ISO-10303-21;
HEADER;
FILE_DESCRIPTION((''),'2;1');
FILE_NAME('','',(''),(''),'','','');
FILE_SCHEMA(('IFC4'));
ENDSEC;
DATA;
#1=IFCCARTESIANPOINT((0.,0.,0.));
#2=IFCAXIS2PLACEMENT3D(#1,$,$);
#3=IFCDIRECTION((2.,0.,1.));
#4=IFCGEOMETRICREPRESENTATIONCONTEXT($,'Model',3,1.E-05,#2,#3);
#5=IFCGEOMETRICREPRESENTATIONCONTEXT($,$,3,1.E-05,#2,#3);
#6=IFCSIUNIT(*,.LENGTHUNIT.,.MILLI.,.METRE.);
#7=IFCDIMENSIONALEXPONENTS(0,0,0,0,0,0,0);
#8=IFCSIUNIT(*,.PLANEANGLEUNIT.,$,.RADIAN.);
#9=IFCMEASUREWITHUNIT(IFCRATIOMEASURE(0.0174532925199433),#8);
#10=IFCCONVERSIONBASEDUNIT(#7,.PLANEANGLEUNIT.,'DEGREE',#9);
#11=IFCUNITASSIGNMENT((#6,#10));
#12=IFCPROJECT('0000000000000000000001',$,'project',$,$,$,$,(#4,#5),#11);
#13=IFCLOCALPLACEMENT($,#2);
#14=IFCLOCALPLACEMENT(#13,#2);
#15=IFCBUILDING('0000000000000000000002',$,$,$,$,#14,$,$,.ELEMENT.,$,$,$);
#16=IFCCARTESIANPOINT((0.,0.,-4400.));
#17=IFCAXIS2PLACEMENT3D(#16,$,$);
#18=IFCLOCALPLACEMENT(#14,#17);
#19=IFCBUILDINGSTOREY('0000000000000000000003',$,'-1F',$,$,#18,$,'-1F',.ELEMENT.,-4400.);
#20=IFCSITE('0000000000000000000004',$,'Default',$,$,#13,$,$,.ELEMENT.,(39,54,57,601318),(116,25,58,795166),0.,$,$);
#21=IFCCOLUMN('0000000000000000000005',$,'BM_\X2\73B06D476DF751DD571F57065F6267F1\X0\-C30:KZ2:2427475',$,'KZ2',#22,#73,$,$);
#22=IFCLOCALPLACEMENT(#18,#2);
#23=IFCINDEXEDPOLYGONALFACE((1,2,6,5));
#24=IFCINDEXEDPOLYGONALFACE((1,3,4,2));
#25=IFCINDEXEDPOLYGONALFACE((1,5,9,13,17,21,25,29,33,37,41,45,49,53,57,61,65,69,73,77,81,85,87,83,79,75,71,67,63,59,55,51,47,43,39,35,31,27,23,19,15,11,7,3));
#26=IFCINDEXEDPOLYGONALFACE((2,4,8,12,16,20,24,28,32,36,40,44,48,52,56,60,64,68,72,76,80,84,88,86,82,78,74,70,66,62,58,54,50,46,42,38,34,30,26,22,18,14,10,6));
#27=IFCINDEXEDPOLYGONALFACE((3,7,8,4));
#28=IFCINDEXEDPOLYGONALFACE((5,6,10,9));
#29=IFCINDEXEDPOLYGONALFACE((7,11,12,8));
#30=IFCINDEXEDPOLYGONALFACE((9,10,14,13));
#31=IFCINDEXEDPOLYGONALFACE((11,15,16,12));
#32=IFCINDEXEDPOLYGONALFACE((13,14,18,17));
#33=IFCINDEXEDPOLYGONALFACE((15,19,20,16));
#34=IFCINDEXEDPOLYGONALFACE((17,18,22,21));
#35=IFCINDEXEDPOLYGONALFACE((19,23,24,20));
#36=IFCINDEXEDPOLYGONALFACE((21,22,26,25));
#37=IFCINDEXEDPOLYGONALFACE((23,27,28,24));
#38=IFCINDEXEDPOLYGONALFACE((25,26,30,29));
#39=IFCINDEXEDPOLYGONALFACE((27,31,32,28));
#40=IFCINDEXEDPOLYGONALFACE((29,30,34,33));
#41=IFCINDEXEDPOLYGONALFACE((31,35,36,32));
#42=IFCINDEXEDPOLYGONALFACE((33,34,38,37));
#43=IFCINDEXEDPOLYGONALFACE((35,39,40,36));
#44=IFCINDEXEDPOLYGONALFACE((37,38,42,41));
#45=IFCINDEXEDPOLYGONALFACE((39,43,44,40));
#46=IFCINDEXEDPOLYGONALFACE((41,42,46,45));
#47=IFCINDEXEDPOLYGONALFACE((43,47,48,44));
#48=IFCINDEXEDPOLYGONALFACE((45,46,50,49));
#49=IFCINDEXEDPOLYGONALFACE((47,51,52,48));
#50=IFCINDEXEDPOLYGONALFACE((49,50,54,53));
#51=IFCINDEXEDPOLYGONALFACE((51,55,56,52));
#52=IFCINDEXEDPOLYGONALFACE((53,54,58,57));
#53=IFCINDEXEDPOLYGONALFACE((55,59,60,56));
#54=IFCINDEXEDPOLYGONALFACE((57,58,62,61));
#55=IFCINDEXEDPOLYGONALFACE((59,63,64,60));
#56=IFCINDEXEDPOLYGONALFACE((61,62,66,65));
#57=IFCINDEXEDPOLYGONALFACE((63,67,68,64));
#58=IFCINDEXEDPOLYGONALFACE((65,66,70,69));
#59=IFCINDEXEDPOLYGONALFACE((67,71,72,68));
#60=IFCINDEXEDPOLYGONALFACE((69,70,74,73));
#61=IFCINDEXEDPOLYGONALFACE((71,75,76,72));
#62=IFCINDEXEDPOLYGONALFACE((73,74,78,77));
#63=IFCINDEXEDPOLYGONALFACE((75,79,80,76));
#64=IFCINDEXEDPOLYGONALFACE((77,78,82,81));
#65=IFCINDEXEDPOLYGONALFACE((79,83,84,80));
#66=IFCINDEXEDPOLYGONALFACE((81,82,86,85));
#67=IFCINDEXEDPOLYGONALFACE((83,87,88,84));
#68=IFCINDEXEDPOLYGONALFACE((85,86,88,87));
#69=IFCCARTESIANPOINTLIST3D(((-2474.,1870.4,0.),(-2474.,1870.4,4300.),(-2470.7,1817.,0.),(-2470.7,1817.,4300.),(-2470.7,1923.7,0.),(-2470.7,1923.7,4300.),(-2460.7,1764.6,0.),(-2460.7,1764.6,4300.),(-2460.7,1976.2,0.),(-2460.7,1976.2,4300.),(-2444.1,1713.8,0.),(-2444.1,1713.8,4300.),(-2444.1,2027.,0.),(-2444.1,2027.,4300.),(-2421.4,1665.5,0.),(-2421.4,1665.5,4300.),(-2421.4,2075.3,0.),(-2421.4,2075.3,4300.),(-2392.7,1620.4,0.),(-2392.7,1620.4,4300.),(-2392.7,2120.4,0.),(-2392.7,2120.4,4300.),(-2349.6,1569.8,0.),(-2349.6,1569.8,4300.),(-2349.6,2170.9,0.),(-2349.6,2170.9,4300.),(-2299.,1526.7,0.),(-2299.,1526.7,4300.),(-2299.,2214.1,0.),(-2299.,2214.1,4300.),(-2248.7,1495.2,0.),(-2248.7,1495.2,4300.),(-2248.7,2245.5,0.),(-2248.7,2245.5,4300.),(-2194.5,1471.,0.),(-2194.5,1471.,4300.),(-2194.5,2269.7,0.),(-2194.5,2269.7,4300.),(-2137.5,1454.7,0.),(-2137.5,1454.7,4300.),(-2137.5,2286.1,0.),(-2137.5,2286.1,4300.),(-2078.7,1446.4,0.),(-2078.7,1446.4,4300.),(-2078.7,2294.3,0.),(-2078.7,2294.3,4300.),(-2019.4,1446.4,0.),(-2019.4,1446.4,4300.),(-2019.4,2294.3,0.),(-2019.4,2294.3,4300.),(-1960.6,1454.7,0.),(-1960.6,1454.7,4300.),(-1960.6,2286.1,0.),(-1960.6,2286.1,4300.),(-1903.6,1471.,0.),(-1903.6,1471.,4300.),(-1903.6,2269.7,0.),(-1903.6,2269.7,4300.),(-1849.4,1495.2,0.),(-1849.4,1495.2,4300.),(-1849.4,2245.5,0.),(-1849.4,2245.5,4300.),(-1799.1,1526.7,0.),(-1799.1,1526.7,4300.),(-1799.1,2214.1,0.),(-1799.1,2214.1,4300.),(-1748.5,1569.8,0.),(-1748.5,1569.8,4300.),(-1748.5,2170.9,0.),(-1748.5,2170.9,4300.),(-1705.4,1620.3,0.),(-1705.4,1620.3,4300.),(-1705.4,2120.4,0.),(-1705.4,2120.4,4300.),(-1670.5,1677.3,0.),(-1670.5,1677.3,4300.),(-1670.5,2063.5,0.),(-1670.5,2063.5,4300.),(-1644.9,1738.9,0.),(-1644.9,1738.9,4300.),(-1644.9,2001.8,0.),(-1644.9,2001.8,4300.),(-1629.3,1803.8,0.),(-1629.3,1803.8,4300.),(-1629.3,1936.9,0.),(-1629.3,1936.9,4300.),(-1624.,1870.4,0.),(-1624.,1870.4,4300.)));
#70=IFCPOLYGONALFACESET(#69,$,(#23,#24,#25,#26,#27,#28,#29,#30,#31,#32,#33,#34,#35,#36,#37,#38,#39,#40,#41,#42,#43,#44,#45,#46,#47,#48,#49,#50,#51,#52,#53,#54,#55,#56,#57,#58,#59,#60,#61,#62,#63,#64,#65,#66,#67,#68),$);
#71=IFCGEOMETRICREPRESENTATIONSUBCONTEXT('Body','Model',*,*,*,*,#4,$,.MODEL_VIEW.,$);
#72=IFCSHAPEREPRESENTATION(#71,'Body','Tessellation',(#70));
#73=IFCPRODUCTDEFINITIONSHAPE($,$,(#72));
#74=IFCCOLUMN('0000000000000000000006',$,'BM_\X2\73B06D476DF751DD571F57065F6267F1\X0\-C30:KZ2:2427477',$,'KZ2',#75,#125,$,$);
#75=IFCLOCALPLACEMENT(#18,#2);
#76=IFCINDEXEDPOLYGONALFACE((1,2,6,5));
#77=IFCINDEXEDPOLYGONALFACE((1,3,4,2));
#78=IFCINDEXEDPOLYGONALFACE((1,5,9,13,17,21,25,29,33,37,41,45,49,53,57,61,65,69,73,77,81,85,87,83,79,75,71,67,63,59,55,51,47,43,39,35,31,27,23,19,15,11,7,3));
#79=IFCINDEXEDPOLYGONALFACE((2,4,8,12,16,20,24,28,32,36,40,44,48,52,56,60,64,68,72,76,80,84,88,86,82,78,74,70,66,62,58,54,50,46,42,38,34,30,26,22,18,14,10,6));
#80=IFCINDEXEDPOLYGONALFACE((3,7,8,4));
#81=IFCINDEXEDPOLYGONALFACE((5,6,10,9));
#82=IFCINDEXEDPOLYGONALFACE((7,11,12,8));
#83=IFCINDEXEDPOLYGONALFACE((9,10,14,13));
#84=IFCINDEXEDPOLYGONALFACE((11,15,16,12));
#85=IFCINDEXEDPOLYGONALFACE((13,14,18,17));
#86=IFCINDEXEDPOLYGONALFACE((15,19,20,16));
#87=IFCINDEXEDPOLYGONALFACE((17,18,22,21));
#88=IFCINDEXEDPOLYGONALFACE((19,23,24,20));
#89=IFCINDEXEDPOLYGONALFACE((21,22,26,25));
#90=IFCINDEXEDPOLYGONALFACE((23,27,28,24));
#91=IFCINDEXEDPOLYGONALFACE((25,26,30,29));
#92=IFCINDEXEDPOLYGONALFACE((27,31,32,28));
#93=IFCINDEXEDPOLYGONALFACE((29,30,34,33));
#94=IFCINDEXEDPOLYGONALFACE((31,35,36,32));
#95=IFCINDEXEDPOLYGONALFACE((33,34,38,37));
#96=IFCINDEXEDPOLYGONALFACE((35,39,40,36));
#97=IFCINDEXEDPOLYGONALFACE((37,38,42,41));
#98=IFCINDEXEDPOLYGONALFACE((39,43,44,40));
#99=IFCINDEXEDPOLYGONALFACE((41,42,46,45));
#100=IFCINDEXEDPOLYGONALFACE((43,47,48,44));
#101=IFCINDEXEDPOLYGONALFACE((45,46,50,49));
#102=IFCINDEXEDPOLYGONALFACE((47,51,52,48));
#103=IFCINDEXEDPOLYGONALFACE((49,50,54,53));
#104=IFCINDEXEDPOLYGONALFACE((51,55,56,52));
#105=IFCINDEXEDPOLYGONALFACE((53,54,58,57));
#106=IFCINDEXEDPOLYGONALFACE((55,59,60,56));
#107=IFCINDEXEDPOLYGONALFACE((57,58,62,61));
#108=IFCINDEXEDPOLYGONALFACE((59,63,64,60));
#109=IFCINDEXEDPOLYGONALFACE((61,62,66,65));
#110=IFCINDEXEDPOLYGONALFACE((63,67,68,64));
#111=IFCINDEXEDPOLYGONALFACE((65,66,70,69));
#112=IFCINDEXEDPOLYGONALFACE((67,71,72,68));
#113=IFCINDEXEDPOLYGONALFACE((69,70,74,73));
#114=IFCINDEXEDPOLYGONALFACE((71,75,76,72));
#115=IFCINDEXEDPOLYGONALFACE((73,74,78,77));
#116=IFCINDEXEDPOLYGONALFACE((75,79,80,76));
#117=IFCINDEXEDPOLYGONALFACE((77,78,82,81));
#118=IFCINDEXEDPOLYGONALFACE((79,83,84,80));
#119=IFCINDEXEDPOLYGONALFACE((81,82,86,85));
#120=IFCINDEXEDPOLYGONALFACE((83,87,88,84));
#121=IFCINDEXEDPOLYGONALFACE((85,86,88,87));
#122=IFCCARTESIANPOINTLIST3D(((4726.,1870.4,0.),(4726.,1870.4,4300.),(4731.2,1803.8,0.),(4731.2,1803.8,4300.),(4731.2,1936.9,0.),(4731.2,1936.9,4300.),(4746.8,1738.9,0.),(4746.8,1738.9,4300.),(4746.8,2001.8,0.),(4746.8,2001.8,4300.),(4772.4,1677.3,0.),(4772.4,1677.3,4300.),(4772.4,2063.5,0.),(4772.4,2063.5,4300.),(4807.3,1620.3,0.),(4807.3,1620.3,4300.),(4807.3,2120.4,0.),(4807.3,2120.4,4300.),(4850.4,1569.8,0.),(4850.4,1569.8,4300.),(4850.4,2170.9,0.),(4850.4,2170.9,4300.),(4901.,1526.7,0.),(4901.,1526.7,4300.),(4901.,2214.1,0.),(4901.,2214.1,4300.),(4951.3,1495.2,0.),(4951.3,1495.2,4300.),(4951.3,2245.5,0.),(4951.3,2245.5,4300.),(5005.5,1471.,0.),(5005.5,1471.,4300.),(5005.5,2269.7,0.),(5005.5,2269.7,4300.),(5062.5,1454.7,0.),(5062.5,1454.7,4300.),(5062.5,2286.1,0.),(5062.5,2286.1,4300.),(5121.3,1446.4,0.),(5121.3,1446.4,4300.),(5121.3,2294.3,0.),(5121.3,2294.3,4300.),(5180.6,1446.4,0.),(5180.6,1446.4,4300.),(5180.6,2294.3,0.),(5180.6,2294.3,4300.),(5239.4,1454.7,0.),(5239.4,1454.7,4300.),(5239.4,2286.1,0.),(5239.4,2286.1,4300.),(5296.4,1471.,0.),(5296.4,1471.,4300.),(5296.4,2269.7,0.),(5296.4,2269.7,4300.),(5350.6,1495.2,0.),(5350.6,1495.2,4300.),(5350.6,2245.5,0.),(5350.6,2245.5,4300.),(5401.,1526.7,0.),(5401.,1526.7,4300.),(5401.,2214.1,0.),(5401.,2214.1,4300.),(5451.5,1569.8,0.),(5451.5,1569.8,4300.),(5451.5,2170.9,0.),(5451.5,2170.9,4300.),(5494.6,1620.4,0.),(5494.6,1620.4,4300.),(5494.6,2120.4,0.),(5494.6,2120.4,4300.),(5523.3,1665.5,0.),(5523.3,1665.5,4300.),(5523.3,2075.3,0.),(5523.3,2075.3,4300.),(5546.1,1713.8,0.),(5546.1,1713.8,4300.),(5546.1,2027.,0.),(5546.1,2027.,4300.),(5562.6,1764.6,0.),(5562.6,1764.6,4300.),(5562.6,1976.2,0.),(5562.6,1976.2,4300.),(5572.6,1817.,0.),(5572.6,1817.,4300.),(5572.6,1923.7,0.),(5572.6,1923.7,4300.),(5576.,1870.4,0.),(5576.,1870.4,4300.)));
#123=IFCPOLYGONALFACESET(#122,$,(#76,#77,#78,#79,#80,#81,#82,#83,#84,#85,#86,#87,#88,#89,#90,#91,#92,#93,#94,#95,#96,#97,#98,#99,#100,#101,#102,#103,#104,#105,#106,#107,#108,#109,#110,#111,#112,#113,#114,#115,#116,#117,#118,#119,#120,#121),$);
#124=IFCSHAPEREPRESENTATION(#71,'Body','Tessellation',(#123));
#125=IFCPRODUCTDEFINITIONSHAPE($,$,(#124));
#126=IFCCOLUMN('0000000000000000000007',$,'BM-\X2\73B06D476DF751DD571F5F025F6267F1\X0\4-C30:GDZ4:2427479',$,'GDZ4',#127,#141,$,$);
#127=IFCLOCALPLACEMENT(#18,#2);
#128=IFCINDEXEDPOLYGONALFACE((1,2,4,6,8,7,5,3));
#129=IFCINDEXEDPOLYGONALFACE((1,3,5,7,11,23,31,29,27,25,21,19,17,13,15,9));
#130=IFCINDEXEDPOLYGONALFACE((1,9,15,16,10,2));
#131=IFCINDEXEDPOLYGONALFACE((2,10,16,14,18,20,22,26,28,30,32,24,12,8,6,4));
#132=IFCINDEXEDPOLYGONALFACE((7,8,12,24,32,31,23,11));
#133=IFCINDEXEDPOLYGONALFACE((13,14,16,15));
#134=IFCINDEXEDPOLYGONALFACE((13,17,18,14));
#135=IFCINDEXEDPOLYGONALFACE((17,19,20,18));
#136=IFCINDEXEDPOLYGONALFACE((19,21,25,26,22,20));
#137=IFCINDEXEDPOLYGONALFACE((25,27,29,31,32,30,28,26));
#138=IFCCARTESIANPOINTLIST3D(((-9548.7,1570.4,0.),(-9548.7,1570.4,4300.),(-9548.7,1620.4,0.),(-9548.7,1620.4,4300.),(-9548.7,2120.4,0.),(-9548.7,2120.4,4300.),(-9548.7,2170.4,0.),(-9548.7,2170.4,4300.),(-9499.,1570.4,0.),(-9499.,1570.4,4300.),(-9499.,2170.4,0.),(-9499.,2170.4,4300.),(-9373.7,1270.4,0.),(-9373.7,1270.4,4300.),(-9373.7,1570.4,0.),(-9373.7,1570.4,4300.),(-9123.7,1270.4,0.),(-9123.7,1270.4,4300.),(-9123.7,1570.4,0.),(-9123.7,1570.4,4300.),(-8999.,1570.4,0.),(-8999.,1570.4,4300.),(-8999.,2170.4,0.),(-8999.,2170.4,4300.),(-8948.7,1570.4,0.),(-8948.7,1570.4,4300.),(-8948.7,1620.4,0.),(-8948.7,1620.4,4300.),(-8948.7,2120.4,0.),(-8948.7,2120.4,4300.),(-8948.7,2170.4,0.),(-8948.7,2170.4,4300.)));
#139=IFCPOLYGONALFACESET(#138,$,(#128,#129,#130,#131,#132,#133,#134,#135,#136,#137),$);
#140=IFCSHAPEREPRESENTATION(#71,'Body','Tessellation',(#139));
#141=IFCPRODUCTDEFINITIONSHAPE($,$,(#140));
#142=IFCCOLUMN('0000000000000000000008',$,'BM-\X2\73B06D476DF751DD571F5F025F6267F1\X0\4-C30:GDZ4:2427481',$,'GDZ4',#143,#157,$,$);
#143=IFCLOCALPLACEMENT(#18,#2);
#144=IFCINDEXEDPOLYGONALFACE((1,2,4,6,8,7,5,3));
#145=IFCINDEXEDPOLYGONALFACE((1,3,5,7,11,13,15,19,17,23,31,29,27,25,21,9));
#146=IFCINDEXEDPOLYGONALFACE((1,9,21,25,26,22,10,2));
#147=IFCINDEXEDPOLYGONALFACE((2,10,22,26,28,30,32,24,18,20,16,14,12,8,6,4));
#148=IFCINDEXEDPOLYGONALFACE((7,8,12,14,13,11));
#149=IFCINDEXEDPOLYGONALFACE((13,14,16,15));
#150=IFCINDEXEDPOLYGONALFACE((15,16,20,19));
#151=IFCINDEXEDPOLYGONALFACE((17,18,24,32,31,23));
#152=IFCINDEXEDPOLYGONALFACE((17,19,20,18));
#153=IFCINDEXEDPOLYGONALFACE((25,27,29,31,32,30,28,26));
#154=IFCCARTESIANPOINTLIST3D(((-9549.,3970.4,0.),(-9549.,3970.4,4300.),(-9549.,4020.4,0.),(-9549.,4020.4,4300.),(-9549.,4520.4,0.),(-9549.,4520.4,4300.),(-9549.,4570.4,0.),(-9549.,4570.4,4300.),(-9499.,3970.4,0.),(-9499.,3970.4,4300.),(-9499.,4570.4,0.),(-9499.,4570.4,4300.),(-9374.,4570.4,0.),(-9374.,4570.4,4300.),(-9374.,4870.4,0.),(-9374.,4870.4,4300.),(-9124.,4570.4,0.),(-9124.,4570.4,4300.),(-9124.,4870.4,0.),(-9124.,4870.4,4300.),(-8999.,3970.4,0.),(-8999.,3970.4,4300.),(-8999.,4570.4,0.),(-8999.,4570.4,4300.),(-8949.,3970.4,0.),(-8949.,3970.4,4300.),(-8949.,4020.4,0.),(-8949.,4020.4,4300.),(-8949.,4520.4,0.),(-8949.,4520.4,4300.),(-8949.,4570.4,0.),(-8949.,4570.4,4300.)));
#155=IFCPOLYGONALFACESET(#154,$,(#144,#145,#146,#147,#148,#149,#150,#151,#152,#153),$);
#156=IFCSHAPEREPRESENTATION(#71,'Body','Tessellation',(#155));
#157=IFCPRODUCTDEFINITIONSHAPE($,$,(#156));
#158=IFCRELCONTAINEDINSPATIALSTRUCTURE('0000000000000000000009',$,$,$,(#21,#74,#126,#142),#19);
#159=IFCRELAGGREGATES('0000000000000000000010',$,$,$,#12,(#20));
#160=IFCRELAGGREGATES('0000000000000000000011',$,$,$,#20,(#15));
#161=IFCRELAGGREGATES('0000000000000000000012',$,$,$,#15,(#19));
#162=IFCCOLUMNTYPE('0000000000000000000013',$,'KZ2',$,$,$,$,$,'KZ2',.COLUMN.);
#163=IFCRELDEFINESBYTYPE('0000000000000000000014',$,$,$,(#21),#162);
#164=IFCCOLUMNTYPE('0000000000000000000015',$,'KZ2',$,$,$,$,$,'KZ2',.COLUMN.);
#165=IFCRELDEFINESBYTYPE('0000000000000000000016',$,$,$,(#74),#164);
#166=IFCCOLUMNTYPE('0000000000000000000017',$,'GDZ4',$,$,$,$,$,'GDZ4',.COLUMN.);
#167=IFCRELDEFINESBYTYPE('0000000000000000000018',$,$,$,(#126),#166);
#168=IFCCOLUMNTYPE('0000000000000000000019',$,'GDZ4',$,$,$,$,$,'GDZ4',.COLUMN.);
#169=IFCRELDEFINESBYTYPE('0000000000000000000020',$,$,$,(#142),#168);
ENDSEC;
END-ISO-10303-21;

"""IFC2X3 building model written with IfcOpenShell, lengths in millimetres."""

from ifc_helpers import new_model, entity, si_unit, converted_unit, direction, frame, origin, place, context, subcontext, project, spatial, polyline, outline, extrude, source, transform, mapped, type_object, type_shapes, element, save


model = new_model("IFC2X3")

# Units and contexts
model_context = context("Model", 3, precision=1e-05, world=origin(), true_north=direction((2.0, 0.0, 1.0)))
context_of_model = context(None, 3, precision=1e-05, world=origin(), true_north=direction((2.0, 0.0, 1.0)))
body_context = subcontext(model_context, "Body", "Model", "MODEL_VIEW")
ifc_project = project(units=[si_unit("LENGTHUNIT", "METRE", prefix="MILLI"), converted_unit("PLANEANGLEUNIT", "DEGREE", entity("IfcRatioMeasure", 0.0174532925199433), si_unit("PLANEANGLEUNIT", "RADIAN"), dimensions=[0, 0, 0, 0, 0, 0, 0])], contexts=[model_context, context_of_model])

# Site, building, storey
site_placement = place(None, origin())
site = spatial("IfcSite", under=ifc_project, at=site_placement, Name="Default", CompositionType="ELEMENT", RefLatitude=(39, 54, 57, 601318), RefLongitude=(116, 25, 58, 795166), RefElevation=0.0)
building_placement = place(site_placement, origin())
building = spatial("IfcBuilding", under=site, at=building_placement, CompositionType="ELEMENT")
storey_placement = place(building_placement, frame((0.0, 0.0, -4400.0)))
storey = spatial("IfcBuildingStorey", under=building, at=storey_placement, Name="-1F", LongName="-1F", CompositionType="ELEMENT", Elevation=-4400.0)

# Columns
column_type_1 = type_object("IfcColumnType", Name="KZ2", ElementType="KZ2", PredefinedType="COLUMN")
shared_shape_1 = source(origin(), body_context, "Body", "SweptSolid", [
    extrude(outline(polyline([(-2474.0, 1870.4), (-2470.7, 1817.0), (-2460.7, 1764.6), (-2444.1, 1713.8), (-2421.4, 1665.5), (-2392.7, 1620.4), (-2349.6, 1569.8), (-2299.0, 1526.7), (-2248.7, 1495.2), (-2194.5, 1471.0), (-2137.5, 1454.7), (-2078.7, 1446.4), (-2019.4, 1446.4), (-1960.6, 1454.7), (-1903.6, 1471.0), (-1849.4, 1495.2), (-1799.1, 1526.7), (-1748.5, 1569.8), (-1705.4, 1620.3), (-1670.5, 1677.3), (-1644.9, 1738.9), (-1629.3, 1803.8), (-1624.0, 1870.4), (-1629.3, 1936.9), (-1644.9, 2001.8), (-1670.5, 2063.5), (-1705.4, 2120.4), (-1748.5, 2170.9), (-1799.1, 2214.1), (-1849.4, 2245.5), (-1903.6, 2269.7), (-1960.6, 2286.1), (-2019.4, 2294.3), (-2078.7, 2294.3), (-2137.5, 2286.1), (-2194.5, 2269.7), (-2248.7, 2245.5), (-2299.0, 2214.1), (-2349.6, 2170.9), (-2392.7, 2120.4), (-2421.4, 2075.3), (-2444.1, 2027.0), (-2460.7, 1976.2), (-2470.7, 1923.7), (-2474.0, 1870.4)])), origin(), (0.0, 0.0, 1.0), 4300.0),
])
type_shapes(column_type_1, [shared_shape_1])
column_1_placement = place(storey_placement, origin())
element("IfcColumn", 1, at=column_1_placement, inside=storey, type_object=column_type_1, Name="BM_现浇混凝土圆形柱-C30:KZ2:2427475", ObjectType="KZ2", context=body_context, shape_type="MappedRepresentation", body=[
    mapped(shared_shape_1, transform((0.0, 0.0, 0.0), scale=1.0)),
])
column_type_2 = type_object("IfcColumnType", Name="KZ2", ElementType="KZ2", PredefinedType="COLUMN")
shared_shape_2 = source(origin(), body_context, "Body", "SweptSolid", [
    extrude(outline(polyline([(4726.0, 1870.4), (4731.2, 1803.8), (4746.8, 1738.9), (4772.4, 1677.3), (4807.3, 1620.3), (4850.4, 1569.8), (4901.0, 1526.7), (4951.3, 1495.2), (5005.5, 1471.0), (5062.5, 1454.7), (5121.3, 1446.4), (5180.6, 1446.4), (5239.4, 1454.7), (5296.4, 1471.0), (5350.6, 1495.2), (5401.0, 1526.7), (5451.5, 1569.8), (5494.6, 1620.4), (5523.3, 1665.5), (5546.1, 1713.8), (5562.6, 1764.6), (5572.6, 1817.0), (5576.0, 1870.4), (5572.6, 1923.7), (5562.6, 1976.2), (5546.1, 2027.0), (5523.3, 2075.3), (5494.6, 2120.4), (5451.5, 2170.9), (5401.0, 2214.1), (5350.6, 2245.5), (5296.4, 2269.7), (5239.4, 2286.1), (5180.6, 2294.3), (5121.3, 2294.3), (5062.5, 2286.1), (5005.5, 2269.7), (4951.3, 2245.5), (4901.0, 2214.1), (4850.4, 2170.9), (4807.3, 2120.4), (4772.4, 2063.5), (4746.8, 2001.8), (4731.2, 1936.9), (4726.0, 1870.4)])), origin(), (0.0, 0.0, 1.0), 4300.0),
])
type_shapes(column_type_2, [shared_shape_2])
column_2_placement = place(storey_placement, origin())
element("IfcColumn", 2, at=column_2_placement, inside=storey, type_object=column_type_2, Name="BM_现浇混凝土圆形柱-C30:KZ2:2427477", ObjectType="KZ2", context=body_context, shape_type="MappedRepresentation", body=[
    mapped(shared_shape_2, transform((0.0, 0.0, 0.0), scale=1.0)),
])
column_type_3 = type_object("IfcColumnType", Name="GDZ4", ElementType="GDZ4", PredefinedType="COLUMN")
shared_shape_3 = source(origin(), body_context, "Body", "SweptSolid", [
    extrude(outline(polyline([(-8948.7, 1570.4), (-8948.7, 1620.4), (-8948.7, 2120.4), (-8948.7, 2170.4), (-8999.0, 2170.4), (-9499.0, 2170.4), (-9548.7, 2170.4), (-9548.7, 2120.4), (-9548.7, 1620.4), (-9548.7, 1570.4), (-9499.0, 1570.4), (-9373.7, 1570.4), (-9373.7, 1270.4), (-9123.7, 1270.4), (-9123.7, 1570.4), (-8999.0, 1570.4), (-8948.7, 1570.4)])), origin(), (0.0, 0.0, 1.0), 4300.0),
])
type_shapes(column_type_3, [shared_shape_3])
column_3_placement = place(storey_placement, origin())
element("IfcColumn", 3, at=column_3_placement, inside=storey, type_object=column_type_3, Name="BM-现浇混凝土异形柱4-C30:GDZ4:2427479", ObjectType="GDZ4", context=body_context, shape_type="MappedRepresentation", body=[
    mapped(shared_shape_3, transform((0.0, 0.0, 0.0), scale=1.0)),
])
column_type_4 = type_object("IfcColumnType", Name="GDZ4", ElementType="GDZ4", PredefinedType="COLUMN")
shared_shape_4 = source(origin(), body_context, "Body", "SweptSolid", [
    extrude(outline(polyline([(-8949.0, 4570.4), (-8999.0, 4570.4), (-9124.0, 4570.4), (-9124.0, 4870.4), (-9374.0, 4870.4), (-9374.0, 4570.4), (-9499.0, 4570.4), (-9549.0, 4570.4), (-9549.0, 4520.4), (-9549.0, 4020.4), (-9549.0, 3970.4), (-9499.0, 3970.4), (-8999.0, 3970.4), (-8949.0, 3970.4), (-8949.0, 4020.4), (-8949.0, 4520.4), (-8949.0, 4570.4)])), origin(), (0.0, 0.0, 1.0), 4300.0),
])
type_shapes(column_type_4, [shared_shape_4])
column_4_placement = place(storey_placement, origin())
element("IfcColumn", 4, at=column_4_placement, inside=storey, type_object=column_type_4, Name="BM-现浇混凝土异形柱4-C30:GDZ4:2427481", ObjectType="GDZ4", context=body_context, shape_type="MappedRepresentation", body=[
    mapped(shared_shape_4, transform((0.0, 0.0, 0.0), scale=1.0)),
])

save(model, "model.ifc")
